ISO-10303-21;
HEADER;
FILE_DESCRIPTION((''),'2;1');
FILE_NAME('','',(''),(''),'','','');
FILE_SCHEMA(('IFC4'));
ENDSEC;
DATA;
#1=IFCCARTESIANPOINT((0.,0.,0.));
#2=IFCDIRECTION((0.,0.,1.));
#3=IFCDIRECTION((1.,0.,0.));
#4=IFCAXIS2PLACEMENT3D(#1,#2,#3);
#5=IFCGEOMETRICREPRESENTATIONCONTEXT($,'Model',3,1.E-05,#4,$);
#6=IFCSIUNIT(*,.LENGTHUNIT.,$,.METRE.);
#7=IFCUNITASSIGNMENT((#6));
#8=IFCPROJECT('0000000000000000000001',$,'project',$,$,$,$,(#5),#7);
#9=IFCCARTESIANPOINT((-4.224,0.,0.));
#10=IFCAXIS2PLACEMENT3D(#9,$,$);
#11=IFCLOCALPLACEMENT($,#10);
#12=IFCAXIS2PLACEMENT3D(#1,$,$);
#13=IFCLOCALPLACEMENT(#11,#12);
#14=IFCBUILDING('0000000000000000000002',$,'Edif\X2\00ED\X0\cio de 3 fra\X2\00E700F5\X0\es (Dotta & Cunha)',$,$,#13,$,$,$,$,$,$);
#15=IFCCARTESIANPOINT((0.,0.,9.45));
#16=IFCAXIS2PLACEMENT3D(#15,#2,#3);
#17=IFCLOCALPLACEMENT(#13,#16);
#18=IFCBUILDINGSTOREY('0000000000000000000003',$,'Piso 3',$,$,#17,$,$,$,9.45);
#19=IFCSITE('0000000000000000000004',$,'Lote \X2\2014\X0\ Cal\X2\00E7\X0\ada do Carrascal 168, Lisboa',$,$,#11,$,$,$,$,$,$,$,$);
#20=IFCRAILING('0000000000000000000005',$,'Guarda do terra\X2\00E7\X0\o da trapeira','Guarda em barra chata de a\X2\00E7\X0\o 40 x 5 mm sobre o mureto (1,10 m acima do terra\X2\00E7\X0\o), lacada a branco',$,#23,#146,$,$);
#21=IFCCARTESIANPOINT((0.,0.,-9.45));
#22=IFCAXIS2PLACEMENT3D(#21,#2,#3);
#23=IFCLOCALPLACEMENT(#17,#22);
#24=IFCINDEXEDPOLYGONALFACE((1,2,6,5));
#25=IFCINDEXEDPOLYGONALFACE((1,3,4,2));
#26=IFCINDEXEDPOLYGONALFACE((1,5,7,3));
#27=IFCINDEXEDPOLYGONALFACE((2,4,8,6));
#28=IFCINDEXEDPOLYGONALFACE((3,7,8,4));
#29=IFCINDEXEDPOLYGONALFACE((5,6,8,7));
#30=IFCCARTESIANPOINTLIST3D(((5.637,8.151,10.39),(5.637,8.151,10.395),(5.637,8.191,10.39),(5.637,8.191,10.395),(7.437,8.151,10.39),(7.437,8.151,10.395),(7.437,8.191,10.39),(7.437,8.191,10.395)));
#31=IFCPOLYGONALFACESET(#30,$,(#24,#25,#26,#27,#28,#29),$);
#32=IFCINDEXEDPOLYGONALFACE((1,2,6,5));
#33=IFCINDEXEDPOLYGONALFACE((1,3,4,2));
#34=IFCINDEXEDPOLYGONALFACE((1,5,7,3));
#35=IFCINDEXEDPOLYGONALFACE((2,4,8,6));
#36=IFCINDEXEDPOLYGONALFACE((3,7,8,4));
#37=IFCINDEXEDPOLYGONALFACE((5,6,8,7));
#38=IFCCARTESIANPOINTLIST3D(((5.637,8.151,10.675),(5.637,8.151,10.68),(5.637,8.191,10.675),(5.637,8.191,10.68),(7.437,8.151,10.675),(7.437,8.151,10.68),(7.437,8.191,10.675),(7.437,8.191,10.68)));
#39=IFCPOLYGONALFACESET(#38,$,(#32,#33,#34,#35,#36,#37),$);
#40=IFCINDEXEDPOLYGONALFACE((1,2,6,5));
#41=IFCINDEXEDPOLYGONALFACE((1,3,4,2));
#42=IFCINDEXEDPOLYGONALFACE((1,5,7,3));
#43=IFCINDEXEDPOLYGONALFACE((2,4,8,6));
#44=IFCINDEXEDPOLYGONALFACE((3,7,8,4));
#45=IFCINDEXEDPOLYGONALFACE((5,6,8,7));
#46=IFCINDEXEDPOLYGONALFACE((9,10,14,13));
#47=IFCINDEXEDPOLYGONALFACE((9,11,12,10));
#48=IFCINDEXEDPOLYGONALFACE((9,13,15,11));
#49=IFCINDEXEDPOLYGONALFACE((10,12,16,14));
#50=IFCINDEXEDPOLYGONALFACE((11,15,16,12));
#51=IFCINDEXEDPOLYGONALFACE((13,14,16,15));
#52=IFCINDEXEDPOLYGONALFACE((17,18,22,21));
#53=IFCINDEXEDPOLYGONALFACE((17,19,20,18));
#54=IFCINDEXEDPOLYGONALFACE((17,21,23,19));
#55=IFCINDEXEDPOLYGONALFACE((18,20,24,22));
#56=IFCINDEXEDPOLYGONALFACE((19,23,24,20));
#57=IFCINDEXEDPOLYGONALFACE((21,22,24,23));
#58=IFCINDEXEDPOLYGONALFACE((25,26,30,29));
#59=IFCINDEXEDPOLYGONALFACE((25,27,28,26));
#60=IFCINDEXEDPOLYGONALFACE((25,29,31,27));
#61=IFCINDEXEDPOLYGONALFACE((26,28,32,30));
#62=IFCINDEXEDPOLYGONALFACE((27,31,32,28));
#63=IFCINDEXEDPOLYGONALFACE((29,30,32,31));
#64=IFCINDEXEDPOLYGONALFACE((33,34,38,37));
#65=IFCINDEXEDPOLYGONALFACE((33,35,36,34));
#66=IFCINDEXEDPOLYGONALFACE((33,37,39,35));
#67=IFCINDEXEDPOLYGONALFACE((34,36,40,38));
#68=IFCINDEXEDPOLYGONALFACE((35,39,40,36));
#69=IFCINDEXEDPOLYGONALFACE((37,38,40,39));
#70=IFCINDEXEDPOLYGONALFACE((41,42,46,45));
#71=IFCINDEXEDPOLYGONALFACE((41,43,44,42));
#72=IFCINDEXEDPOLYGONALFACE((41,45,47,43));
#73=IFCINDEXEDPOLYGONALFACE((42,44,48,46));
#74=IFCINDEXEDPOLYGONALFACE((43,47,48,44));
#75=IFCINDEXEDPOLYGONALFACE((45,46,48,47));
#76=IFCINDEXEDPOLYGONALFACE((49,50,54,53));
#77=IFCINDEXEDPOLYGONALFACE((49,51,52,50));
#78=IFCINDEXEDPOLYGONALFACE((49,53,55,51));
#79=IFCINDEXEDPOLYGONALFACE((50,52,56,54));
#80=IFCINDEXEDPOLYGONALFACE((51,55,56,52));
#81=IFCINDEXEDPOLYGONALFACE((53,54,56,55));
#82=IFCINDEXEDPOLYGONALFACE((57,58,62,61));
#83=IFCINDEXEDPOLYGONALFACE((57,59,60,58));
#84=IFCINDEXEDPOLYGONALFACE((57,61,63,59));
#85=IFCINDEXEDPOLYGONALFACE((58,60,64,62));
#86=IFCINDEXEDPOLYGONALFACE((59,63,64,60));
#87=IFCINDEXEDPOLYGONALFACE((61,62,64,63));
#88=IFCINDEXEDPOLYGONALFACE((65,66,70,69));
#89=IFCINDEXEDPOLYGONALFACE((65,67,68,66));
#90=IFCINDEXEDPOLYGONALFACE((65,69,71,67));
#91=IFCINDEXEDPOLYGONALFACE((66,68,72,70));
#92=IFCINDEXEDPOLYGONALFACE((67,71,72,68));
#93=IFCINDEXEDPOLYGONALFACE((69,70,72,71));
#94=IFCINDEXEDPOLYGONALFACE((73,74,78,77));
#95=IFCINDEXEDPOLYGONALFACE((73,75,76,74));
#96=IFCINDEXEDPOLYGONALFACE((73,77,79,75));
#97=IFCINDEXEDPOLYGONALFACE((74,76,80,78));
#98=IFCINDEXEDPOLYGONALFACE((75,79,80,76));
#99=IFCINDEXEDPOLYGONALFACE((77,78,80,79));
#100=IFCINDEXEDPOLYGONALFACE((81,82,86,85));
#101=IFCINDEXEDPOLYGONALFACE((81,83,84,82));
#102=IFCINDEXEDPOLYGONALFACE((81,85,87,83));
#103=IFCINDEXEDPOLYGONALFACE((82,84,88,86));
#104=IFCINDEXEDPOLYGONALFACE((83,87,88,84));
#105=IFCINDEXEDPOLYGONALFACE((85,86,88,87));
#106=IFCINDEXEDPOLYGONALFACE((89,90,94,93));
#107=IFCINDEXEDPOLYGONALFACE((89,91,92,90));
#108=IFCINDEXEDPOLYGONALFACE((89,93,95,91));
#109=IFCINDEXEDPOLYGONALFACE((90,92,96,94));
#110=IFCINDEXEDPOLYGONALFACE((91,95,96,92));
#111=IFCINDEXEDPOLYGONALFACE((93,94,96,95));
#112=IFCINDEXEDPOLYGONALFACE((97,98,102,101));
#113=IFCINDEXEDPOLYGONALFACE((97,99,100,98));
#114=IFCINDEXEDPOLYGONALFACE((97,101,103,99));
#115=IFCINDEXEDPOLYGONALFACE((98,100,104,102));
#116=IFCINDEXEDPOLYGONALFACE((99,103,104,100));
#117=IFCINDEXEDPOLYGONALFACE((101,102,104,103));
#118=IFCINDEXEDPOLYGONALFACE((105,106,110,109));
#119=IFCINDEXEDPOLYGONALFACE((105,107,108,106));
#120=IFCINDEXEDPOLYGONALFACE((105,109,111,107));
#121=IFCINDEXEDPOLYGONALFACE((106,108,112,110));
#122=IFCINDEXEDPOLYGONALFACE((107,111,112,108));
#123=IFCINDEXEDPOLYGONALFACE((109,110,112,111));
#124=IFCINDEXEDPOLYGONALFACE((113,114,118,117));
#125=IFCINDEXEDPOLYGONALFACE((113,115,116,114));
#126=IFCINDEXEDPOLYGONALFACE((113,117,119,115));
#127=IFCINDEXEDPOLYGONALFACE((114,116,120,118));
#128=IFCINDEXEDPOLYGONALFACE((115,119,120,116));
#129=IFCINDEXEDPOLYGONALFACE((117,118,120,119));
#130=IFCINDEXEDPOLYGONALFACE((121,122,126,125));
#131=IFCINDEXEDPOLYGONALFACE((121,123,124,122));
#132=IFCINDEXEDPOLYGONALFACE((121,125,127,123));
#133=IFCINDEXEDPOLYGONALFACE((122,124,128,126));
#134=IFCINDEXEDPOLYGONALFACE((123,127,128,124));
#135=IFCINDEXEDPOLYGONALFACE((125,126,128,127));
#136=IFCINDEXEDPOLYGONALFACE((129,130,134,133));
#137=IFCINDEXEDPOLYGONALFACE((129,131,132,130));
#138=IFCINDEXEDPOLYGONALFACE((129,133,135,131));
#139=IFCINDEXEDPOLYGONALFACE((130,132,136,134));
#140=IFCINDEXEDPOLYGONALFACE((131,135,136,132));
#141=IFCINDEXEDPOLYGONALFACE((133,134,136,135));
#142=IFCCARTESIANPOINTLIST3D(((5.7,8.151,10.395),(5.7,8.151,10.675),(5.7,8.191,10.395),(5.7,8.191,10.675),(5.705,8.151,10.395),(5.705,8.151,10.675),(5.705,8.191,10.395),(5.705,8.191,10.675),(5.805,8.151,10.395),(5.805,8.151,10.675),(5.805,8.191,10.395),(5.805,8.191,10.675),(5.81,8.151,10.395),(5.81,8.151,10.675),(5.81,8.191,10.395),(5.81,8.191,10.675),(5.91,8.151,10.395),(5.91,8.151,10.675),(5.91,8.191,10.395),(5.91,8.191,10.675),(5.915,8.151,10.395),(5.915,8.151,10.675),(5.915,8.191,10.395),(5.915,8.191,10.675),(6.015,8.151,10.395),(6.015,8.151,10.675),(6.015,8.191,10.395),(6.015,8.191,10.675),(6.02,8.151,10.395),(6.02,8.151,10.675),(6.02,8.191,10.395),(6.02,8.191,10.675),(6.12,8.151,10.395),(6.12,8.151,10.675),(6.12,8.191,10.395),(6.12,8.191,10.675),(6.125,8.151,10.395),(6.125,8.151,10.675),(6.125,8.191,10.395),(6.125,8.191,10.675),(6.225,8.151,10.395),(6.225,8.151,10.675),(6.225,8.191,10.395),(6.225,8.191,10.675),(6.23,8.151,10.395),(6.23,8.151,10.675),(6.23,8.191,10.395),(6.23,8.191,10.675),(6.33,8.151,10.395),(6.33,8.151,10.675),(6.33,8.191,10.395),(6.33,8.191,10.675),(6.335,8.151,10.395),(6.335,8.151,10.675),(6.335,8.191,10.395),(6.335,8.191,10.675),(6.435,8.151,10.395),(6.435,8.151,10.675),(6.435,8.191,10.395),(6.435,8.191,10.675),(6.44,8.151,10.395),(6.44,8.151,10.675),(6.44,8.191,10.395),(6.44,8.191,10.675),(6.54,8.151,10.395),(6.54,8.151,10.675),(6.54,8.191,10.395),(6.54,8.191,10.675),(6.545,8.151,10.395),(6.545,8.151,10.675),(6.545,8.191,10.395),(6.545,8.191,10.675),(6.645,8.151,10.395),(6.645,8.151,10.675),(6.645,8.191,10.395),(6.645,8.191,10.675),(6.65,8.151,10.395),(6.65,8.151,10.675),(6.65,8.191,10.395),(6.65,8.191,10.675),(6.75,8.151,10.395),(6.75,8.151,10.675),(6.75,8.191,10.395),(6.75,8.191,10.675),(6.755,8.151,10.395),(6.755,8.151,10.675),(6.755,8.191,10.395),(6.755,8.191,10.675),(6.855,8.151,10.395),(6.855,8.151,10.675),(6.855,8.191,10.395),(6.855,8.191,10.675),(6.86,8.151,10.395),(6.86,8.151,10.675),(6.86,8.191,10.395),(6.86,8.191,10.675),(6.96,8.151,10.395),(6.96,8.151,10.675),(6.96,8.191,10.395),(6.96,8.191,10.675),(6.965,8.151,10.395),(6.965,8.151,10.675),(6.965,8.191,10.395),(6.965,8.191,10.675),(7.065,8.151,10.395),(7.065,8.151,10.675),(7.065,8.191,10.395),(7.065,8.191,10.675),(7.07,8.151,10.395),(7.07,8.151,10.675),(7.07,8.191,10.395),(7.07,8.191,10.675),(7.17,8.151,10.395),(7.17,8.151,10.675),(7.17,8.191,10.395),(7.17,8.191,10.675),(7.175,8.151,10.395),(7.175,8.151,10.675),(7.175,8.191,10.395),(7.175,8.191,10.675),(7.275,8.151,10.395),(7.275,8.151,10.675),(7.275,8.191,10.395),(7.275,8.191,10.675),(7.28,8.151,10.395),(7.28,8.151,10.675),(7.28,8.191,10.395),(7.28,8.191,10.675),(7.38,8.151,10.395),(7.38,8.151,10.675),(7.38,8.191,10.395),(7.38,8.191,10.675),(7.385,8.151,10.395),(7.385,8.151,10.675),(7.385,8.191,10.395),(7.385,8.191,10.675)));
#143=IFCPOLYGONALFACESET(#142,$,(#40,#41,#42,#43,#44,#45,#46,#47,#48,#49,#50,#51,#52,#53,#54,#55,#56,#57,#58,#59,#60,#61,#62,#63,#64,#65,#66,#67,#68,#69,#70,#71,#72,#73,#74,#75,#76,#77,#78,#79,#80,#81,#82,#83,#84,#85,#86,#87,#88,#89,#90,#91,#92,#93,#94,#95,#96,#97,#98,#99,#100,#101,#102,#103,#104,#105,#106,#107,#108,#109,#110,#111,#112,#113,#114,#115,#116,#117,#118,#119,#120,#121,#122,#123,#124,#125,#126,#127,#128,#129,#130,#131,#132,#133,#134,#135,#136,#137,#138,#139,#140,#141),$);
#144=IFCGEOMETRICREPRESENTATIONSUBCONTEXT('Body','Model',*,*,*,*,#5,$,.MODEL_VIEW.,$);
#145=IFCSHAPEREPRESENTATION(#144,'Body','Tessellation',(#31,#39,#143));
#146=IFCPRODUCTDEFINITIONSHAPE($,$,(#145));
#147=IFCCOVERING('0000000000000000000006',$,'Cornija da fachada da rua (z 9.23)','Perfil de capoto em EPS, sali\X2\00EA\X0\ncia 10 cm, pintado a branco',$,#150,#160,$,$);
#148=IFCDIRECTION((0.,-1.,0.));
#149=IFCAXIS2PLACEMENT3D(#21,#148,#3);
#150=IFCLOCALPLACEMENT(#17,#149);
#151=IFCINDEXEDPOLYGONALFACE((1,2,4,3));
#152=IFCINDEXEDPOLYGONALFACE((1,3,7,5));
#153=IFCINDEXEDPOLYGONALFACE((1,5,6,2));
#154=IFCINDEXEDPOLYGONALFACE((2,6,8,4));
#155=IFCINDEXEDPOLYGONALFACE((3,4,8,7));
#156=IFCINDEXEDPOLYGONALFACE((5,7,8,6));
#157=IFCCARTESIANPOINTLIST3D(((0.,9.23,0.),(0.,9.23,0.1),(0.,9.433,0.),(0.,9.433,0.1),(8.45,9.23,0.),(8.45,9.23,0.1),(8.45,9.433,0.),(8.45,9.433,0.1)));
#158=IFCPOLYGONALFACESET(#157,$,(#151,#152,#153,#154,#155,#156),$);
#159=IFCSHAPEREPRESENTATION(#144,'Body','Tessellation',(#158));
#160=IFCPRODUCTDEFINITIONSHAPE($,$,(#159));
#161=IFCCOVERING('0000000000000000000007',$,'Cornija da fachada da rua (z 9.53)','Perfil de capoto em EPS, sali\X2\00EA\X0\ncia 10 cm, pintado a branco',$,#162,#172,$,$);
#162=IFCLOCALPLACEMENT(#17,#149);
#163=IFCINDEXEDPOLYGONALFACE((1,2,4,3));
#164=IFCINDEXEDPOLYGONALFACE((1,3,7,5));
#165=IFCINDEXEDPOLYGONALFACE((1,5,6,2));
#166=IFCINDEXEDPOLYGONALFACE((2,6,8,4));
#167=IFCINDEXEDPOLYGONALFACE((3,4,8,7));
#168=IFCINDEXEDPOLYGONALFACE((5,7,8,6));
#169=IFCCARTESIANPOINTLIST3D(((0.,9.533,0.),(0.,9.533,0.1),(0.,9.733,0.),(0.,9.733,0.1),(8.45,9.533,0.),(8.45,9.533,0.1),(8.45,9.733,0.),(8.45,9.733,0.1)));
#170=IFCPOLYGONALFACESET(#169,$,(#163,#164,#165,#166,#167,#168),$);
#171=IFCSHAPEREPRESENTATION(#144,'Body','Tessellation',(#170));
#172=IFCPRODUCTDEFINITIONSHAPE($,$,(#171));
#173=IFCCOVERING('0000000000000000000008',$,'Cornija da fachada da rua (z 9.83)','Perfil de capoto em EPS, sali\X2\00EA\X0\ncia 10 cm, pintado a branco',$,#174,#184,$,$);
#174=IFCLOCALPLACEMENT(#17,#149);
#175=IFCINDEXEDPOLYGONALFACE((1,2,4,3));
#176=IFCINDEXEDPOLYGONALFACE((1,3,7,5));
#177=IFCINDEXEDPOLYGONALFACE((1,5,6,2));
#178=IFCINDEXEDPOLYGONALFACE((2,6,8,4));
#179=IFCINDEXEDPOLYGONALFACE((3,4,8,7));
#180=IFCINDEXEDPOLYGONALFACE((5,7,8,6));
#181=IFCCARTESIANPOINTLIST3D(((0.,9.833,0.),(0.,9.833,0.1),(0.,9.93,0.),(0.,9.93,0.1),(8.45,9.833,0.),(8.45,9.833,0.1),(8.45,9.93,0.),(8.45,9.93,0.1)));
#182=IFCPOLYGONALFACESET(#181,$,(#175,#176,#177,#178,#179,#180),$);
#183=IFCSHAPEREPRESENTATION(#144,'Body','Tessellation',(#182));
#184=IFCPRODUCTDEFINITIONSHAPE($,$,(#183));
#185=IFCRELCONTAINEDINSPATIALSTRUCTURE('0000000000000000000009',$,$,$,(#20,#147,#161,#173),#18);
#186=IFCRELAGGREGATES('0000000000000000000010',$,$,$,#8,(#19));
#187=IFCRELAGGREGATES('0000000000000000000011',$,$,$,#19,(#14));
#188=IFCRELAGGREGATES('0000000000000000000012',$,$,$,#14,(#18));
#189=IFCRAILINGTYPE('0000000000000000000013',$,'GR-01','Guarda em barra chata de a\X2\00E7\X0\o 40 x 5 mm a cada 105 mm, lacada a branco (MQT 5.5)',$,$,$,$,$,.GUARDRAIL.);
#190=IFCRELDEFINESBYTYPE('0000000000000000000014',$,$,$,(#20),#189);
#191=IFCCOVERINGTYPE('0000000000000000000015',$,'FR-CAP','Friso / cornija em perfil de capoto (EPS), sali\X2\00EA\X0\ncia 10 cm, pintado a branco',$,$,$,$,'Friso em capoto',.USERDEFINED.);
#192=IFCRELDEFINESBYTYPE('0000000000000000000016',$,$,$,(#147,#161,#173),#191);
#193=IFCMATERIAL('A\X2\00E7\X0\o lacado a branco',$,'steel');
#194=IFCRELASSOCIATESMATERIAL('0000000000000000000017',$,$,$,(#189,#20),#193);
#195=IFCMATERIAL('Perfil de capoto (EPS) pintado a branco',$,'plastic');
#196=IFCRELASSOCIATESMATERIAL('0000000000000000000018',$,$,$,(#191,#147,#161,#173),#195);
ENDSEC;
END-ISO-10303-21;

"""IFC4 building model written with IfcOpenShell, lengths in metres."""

from ifc_helpers import new_model, entity, si_unit, frame, origin, origin_with_axes, place, context, subcontext, project, spatial, line, indexed_curve, outline, extrude, source, transform, mapped, material, type_object, element, save


model = new_model("IFC4")

# Units and contexts
model_context = context("Model", 3, precision=1e-05, world=origin_with_axes())
body_context = subcontext(model_context, "Body", "Model", "MODEL_VIEW")
ifc_project = project(units=[si_unit("LENGTHUNIT", "METRE")], contexts=[model_context])

# Site, building, storey
site_placement = place(None, frame((-4.224, 0.0, 0.0)))
site = spatial("IfcSite", under=ifc_project, at=site_placement, Name="Lote — Calçada do Carrascal 168, Lisboa")
building_placement = place(site_placement, origin())
building = spatial("IfcBuilding", under=site, at=building_placement, Name="Edifício de 3 frações (Dotta & Cunha)")
storey_placement = place(building_placement, frame((0.0, 0.0, 9.45), z_axis=(0.0, 0.0, 1.0), x_axis=(1.0, 0.0, 0.0)))
storey = spatial("IfcBuildingStorey", under=building, at=storey_placement, Name="Piso 3", Elevation=9.45)

# Railing
ifc_material_1 = material(Name="Aço lacado a branco", Category="steel")
railing_type = type_object("IfcRailingType", Name="GR-01", Description="Guarda em barra chata de aço 40 x 5 mm a cada 105 mm, lacada a branco (MQT 5.5)", PredefinedType="GUARDRAIL", material=ifc_material_1)
shared_shape_1 = source(origin(), body_context, "Body", "CSG", [
    entity("IfcBlock", entity("IfcAxis2Placement3D", entity("IfcCartesianPoint", [0.0, 0.0, 0.0]), entity("IfcDirection", [0.0, 0.0, 1.0]), entity("IfcDirection", [1.0, 0.0, 0.0])), 0.005, 0.04, 0.28),
])
railing_placement = place(storey_placement, frame((0.0, 0.0, -9.45), z_axis=(0.0, 0.0, 1.0), x_axis=(1.0, 0.0, 0.0)))
element("IfcRailing", 1, at=railing_placement, inside=storey, type_object=railing_type, material=ifc_material_1, Name="Guarda do terraço da trapeira", Description="Guarda em barra chata de aço 40 x 5 mm sobre o mureto (1,10 m acima do terraço), lacada a branco", context=body_context, body=[
    entity("IfcBlock", entity("IfcAxis2Placement3D", entity("IfcCartesianPoint", [5.637, 8.151, 10.39]), entity("IfcDirection", [0.0, 0.0, 1.0]), entity("IfcDirection", [1.0, 0.0, 0.0])), 1.8, 0.04, 0.005),
    entity("IfcBlock", entity("IfcAxis2Placement3D", entity("IfcCartesianPoint", [5.637, 8.151, 10.675]), entity("IfcDirection", [0.0, 0.0, 1.0]), entity("IfcDirection", [1.0, 0.0, 0.0])), 1.8, 0.04, 0.005),
    mapped(shared_shape_1, transform((5.7, 8.151, 10.395), scale=1.0)),
    mapped(shared_shape_1, transform((5.805, 8.151, 10.395), scale=1.0)),
    mapped(shared_shape_1, transform((5.91, 8.151, 10.395), scale=1.0)),
    mapped(shared_shape_1, transform((6.015, 8.151, 10.395), scale=1.0)),
    mapped(shared_shape_1, transform((6.12, 8.151, 10.395), scale=1.0)),
    mapped(shared_shape_1, transform((6.225, 8.151, 10.395), scale=1.0)),
    mapped(shared_shape_1, transform((6.33, 8.151, 10.395), scale=1.0)),
    mapped(shared_shape_1, transform((6.435, 8.151, 10.395), scale=1.0)),
    mapped(shared_shape_1, transform((6.54, 8.151, 10.395), scale=1.0)),
    mapped(shared_shape_1, transform((6.645, 8.151, 10.395), scale=1.0)),
    mapped(shared_shape_1, transform((6.75, 8.151, 10.395), scale=1.0)),
    mapped(shared_shape_1, transform((6.855, 8.151, 10.395), scale=1.0)),
    mapped(shared_shape_1, transform((6.96, 8.151, 10.395), scale=1.0)),
    mapped(shared_shape_1, transform((7.065, 8.151, 10.395), scale=1.0)),
    mapped(shared_shape_1, transform((7.17, 8.151, 10.395), scale=1.0)),
    mapped(shared_shape_1, transform((7.275, 8.151, 10.395), scale=1.0)),
    mapped(shared_shape_1, transform((7.38, 8.151, 10.395), scale=1.0)),
])

# Coverings
ifc_material_2 = material(Name="Perfil de capoto (EPS) pintado a branco", Category="plastic")
covering_type_1 = type_object("IfcCoveringType", Name="FR-CAP", Description="Friso / cornija em perfil de capoto (EPS), saliência 10 cm, pintado a branco", ElementType="Friso em capoto", PredefinedType="USERDEFINED", material=ifc_material_2)
covering_1_placement = place(storey_placement, frame((0.0, 0.0, -9.45), z_axis=(0.0, -1.0, 0.0), x_axis=(1.0, 0.0, 0.0)))
element("IfcCovering", 2, at=covering_1_placement, inside=storey, type_object=covering_type_1, material=ifc_material_2, Name="Cornija da fachada da rua (z 9.23)", Description="Perfil de capoto em EPS, saliência 10 cm, pintado a branco", context=body_context, shape_type="SweptSolid", body=[
    extrude(outline(indexed_curve([(8.45, 9.23), (8.45, 9.433), (0.0, 9.433), (0.0, 9.23)], segments=[line(1, 2, 3, 4, 1)])), origin_with_axes(), (0.0, 0.0, 1.0), 0.1),
])
covering_2_placement = place(storey_placement, frame((0.0, 0.0, -9.45), z_axis=(0.0, -1.0, 0.0), x_axis=(1.0, 0.0, 0.0)))
element("IfcCovering", 3, at=covering_2_placement, inside=storey, type_object=covering_type_1, material=ifc_material_2, Name="Cornija da fachada da rua (z 9.53)", Description="Perfil de capoto em EPS, saliência 10 cm, pintado a branco", context=body_context, shape_type="SweptSolid", body=[
    extrude(outline(indexed_curve([(8.45, 9.533), (8.45, 9.733), (0.0, 9.733), (0.0, 9.533)], segments=[line(1, 2, 3, 4, 1)])), origin_with_axes(), (0.0, 0.0, 1.0), 0.1),
])
covering_3_placement = place(storey_placement, frame((0.0, 0.0, -9.45), z_axis=(0.0, -1.0, 0.0), x_axis=(1.0, 0.0, 0.0)))
element("IfcCovering", 4, at=covering_3_placement, inside=storey, type_object=covering_type_1, material=ifc_material_2, Name="Cornija da fachada da rua (z 9.83)", Description="Perfil de capoto em EPS, saliência 10 cm, pintado a branco", context=body_context, shape_type="SweptSolid", body=[
    extrude(outline(indexed_curve([(8.45, 9.833), (8.45, 9.93), (0.0, 9.93), (0.0, 9.833)], segments=[line(1, 2, 3, 4, 1)])), origin_with_axes(), (0.0, 0.0, 1.0), 0.1),
])

save(model, "model.ifc")
